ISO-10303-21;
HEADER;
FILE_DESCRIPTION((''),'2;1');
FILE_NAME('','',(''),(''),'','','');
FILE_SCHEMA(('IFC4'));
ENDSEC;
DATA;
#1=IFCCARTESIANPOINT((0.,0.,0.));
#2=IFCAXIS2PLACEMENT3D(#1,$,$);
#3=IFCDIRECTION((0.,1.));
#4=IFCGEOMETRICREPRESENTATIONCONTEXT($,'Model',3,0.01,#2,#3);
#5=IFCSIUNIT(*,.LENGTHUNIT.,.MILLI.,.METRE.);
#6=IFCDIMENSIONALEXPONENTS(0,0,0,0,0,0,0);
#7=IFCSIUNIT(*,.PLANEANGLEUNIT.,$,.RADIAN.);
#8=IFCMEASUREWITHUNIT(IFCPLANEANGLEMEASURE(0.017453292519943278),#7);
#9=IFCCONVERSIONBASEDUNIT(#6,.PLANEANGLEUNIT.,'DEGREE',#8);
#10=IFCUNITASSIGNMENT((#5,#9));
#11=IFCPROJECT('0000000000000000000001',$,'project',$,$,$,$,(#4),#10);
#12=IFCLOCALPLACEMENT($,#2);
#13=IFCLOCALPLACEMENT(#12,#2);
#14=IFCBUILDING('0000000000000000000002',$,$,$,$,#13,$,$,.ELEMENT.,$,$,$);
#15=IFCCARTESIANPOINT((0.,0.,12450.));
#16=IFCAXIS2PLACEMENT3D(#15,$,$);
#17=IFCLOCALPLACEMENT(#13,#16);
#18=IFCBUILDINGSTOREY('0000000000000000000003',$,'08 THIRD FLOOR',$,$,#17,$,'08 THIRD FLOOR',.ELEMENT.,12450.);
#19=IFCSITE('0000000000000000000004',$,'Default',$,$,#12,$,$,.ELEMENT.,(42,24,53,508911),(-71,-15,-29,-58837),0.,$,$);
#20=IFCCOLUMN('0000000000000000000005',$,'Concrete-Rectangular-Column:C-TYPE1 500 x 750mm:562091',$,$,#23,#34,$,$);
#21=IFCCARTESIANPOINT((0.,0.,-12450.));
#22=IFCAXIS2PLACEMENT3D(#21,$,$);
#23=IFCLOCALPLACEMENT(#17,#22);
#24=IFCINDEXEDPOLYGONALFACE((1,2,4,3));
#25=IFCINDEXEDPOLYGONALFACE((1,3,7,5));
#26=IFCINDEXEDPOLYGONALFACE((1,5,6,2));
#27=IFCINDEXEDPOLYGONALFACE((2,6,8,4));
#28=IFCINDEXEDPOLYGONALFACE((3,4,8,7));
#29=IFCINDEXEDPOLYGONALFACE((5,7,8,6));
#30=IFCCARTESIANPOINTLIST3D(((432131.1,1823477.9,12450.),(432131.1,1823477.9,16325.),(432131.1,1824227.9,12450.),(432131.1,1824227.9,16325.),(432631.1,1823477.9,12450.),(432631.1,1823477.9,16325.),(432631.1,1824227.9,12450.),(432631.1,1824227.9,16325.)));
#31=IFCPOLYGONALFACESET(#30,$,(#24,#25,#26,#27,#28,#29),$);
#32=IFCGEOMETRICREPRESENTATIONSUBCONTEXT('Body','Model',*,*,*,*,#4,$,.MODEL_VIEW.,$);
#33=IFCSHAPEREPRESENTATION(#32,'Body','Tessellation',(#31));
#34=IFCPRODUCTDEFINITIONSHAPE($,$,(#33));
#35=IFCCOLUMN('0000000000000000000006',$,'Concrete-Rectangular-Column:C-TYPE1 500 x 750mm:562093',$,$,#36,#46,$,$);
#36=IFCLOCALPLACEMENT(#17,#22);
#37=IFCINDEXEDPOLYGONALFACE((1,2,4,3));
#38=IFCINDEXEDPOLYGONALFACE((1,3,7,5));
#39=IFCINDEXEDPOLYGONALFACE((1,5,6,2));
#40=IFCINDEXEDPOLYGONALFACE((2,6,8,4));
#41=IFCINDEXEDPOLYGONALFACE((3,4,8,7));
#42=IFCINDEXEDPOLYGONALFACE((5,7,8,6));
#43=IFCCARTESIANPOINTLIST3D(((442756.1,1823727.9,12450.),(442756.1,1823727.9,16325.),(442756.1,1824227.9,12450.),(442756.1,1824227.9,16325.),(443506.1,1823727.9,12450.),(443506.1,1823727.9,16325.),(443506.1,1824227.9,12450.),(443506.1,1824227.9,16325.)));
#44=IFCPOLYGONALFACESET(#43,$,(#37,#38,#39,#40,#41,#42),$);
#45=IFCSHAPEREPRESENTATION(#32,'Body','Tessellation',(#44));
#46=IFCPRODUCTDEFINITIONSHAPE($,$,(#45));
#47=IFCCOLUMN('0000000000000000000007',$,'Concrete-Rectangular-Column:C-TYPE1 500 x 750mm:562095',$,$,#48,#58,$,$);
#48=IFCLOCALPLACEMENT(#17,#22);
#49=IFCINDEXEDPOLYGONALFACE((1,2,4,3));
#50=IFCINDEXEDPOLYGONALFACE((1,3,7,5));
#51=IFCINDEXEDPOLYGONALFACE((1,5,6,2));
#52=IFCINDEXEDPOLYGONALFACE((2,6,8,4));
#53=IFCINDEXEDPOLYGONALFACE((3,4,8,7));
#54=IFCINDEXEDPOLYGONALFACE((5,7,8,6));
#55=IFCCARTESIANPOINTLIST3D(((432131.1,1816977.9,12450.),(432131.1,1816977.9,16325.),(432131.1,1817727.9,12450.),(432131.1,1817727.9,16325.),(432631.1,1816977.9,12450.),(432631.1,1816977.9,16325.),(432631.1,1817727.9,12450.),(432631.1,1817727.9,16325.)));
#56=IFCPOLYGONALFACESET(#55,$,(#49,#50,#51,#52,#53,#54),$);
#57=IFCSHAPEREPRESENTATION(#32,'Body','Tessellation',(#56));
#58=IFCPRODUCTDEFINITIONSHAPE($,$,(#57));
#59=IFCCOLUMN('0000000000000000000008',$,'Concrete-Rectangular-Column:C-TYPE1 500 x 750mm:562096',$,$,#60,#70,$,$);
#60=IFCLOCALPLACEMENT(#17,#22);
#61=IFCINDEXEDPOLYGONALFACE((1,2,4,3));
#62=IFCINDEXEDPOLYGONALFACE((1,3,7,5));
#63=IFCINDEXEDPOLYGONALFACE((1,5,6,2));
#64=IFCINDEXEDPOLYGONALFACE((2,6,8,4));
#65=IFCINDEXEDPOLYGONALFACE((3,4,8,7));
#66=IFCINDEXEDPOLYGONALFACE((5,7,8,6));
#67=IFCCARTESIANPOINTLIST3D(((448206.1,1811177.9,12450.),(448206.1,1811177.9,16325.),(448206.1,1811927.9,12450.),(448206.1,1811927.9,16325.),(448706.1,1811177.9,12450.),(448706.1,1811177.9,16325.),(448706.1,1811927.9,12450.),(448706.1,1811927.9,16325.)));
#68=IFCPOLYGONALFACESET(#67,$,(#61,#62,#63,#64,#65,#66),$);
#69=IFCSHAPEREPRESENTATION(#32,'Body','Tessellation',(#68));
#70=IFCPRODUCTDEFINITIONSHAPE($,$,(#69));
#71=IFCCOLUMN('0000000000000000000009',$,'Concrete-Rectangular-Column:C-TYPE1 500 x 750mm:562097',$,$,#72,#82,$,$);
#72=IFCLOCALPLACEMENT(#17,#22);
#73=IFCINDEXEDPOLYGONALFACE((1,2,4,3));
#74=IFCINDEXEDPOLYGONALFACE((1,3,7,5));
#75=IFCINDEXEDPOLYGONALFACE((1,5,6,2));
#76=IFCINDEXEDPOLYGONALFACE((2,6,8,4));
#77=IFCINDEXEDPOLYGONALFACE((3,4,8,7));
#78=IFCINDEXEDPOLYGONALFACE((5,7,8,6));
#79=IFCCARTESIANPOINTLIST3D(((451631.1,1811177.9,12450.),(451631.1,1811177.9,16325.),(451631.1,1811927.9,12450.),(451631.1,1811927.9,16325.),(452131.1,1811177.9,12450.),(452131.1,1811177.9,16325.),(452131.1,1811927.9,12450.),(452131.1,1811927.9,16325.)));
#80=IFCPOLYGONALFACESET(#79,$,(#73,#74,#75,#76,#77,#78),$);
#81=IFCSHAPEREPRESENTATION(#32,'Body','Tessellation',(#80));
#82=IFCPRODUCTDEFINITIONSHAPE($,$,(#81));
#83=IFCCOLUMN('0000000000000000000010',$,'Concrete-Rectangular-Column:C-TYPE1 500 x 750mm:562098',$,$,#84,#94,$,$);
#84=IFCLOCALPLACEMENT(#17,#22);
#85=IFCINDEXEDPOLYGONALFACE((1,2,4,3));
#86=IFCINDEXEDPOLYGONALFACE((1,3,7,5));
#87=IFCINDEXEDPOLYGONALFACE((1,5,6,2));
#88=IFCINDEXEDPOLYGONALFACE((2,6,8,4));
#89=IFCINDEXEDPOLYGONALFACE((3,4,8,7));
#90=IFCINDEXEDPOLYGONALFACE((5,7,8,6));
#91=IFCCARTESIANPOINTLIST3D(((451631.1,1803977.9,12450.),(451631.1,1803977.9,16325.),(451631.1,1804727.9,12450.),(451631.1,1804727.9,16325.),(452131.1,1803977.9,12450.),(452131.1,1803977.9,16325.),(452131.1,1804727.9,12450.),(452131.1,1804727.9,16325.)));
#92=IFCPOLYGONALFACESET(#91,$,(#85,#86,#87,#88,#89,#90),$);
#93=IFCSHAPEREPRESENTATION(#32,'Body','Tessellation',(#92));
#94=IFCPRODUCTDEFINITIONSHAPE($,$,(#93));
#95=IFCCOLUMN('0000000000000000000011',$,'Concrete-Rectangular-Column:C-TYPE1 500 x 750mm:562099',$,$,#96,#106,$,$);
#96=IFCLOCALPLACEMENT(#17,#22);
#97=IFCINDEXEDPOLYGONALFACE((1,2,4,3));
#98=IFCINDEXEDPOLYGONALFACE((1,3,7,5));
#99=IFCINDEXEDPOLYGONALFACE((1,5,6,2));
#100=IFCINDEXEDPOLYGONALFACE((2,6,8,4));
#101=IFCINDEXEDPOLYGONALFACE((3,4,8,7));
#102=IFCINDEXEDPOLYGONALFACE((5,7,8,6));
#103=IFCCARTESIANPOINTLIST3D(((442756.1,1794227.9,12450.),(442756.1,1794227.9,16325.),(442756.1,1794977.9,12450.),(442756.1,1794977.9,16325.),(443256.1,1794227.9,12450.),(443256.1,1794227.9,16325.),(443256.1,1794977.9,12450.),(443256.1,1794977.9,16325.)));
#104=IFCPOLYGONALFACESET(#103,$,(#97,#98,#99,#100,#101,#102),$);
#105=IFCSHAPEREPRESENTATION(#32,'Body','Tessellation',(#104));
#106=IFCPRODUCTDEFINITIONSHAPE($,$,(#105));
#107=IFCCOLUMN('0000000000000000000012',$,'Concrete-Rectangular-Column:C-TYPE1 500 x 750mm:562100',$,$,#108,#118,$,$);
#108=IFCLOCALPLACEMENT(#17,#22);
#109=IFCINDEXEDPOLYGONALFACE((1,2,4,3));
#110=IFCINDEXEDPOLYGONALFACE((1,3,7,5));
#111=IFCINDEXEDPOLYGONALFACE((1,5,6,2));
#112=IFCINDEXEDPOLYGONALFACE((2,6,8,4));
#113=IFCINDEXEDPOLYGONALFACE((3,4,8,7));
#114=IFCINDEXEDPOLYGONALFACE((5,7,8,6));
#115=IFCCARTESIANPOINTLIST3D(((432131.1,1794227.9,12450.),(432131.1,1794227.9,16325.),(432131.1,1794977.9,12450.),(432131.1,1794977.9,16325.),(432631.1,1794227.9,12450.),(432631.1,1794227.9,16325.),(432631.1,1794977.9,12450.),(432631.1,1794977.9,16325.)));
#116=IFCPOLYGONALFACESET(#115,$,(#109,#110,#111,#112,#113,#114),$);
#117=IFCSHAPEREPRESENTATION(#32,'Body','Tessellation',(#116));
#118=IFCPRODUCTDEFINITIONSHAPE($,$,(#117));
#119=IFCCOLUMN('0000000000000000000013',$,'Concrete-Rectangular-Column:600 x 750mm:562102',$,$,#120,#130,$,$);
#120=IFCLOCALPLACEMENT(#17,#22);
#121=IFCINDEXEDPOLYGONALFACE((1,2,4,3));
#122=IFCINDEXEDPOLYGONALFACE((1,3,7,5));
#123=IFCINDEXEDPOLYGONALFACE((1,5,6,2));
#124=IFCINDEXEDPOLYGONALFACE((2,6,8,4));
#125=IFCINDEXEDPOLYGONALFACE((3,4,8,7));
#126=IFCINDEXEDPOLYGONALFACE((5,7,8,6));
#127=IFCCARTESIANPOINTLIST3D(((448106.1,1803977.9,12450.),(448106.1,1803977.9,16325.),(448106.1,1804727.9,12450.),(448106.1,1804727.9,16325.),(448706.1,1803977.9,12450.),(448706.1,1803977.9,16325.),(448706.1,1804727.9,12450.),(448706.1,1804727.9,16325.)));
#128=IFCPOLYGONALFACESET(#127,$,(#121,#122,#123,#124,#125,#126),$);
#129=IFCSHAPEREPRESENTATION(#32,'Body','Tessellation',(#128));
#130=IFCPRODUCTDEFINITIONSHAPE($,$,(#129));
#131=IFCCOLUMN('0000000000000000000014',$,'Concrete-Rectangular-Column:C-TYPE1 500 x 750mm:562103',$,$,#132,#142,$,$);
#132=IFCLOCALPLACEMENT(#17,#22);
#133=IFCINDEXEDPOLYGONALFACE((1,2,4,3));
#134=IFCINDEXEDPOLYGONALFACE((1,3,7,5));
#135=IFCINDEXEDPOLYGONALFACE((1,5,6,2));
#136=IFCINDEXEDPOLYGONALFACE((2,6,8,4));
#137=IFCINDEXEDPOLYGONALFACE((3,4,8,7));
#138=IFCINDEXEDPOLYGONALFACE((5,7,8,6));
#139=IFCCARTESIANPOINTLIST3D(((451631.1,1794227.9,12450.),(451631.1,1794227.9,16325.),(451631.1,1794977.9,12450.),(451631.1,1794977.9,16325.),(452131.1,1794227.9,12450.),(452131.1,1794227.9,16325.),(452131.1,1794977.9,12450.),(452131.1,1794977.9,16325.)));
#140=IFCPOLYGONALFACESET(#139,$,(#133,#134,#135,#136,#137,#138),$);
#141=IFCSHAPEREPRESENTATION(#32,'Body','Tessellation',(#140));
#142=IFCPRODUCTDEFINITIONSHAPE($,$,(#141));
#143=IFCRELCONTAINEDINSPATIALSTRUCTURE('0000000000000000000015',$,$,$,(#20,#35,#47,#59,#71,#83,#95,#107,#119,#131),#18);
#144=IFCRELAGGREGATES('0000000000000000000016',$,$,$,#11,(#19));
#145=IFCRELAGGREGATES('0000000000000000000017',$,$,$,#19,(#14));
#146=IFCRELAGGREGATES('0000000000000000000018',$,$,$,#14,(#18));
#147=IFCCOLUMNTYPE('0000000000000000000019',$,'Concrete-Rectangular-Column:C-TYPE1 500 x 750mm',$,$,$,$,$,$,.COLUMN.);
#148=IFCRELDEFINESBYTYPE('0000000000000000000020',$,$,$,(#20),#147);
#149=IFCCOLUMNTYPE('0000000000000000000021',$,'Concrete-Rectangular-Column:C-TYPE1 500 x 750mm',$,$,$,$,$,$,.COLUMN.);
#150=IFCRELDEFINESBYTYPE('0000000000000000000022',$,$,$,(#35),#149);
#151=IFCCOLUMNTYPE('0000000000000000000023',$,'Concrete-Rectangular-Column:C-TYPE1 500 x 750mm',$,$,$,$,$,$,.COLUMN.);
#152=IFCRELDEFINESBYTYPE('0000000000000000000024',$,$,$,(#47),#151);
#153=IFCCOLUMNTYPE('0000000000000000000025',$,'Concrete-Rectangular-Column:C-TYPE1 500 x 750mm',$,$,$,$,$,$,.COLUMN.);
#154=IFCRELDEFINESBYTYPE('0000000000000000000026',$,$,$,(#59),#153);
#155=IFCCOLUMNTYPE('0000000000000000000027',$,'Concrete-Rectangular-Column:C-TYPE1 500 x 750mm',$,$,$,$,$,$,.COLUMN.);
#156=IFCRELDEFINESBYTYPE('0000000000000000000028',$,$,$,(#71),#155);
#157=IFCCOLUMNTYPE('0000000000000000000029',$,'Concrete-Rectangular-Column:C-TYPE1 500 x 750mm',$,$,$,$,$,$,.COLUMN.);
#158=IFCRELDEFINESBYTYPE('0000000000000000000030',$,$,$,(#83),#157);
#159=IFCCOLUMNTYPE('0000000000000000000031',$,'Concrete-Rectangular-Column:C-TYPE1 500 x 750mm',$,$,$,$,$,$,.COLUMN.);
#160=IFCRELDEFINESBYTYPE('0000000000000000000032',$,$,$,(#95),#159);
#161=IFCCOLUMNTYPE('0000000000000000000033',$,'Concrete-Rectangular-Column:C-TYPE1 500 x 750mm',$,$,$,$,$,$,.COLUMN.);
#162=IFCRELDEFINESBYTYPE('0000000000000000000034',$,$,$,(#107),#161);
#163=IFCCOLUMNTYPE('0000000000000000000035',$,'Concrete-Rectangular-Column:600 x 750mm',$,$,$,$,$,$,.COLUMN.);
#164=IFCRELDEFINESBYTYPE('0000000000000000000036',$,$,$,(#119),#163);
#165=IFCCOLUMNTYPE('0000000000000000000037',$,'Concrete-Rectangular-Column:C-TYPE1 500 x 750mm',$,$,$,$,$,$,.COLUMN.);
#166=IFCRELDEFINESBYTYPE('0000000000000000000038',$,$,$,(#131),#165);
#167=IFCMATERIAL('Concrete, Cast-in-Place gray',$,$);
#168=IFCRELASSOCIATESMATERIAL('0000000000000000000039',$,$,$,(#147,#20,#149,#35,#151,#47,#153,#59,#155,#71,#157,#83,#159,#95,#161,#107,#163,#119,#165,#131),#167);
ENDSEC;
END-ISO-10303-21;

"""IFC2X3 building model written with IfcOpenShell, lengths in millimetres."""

from ifc_helpers import new_model, entity, si_unit, converted_unit, direction, frame, frame_2d, origin, place, context, subcontext, project, spatial, rectangle, extrude, source, transform, mapped, material, type_object, type_shapes, element, save


model = new_model("IFC2X3")

# Units and contexts
model_context = context("Model", 3, precision=0.01, world=origin(), true_north=direction((0.0, 1.0)))
body_context = subcontext(model_context, "Body", "Model", "MODEL_VIEW")
ifc_project = project(units=[si_unit("LENGTHUNIT", "METRE", prefix="MILLI"), converted_unit("PLANEANGLEUNIT", "DEGREE", entity("IfcPlaneAngleMeasure", 0.017453292519943278), si_unit("PLANEANGLEUNIT", "RADIAN"), dimensions=[0, 0, 0, 0, 0, 0, 0])], contexts=[model_context])

# Site, building, storey
site_placement = place(None, origin())
site = spatial("IfcSite", under=ifc_project, at=site_placement, Name="Default", CompositionType="ELEMENT", RefLatitude=(42, 24, 53, 508911), RefLongitude=(-71, -15, -29, -58837), RefElevation=0.0)
building_placement = place(site_placement, origin())
building = spatial("IfcBuilding", under=site, at=building_placement, CompositionType="ELEMENT")
storey_placement = place(building_placement, frame((0.0, 0.0, 12450.0)))
storey = spatial("IfcBuildingStorey", under=building, at=storey_placement, Name="08 THIRD FLOOR", LongName="08 THIRD FLOOR", CompositionType="ELEMENT", Elevation=12450.0)

# Columns
ifc_material = material(Name="Concrete, Cast-in-Place gray")
column_type_1 = type_object("IfcColumnType", Name="Concrete-Rectangular-Column:C-TYPE1 500 x 750mm", PredefinedType="COLUMN", material=ifc_material)
shared_shape_1 = source(origin(), body_context, "Body", "SweptSolid", [
    extrude(rectangle(XDim=3875.0, YDim=750.0, at=frame_2d((0.0, 0.0), x_axis=(1.0, 0.0))), frame((432131.1, 1823852.9, 14387.5), z_axis=(1.0, 0.0, 0.0), x_axis=(0.0, 0.0, 1.0)), (0.0, 0.0, 1.0), 500.0),
])
type_shapes(column_type_1, [shared_shape_1])
column_1_placement = place(storey_placement, frame((0.0, 0.0, -12450.0)))
element("IfcColumn", 1, at=column_1_placement, inside=storey, type_object=column_type_1, material=ifc_material, Name="Concrete-Rectangular-Column:C-TYPE1 500 x 750mm:562091", context=body_context, shape_type="MappedRepresentation", body=[
    mapped(shared_shape_1, transform((0.0, 0.0, 0.0), scale=1.0)),
])
column_type_2 = type_object("IfcColumnType", Name="Concrete-Rectangular-Column:C-TYPE1 500 x 750mm", PredefinedType="COLUMN", material=ifc_material)
shared_shape_2 = source(origin(), body_context, "Body", "SweptSolid", [
    extrude(rectangle(XDim=500.0, YDim=750.0, at=frame_2d((0.0, 0.0), x_axis=(1.0, 0.0))), frame((443131.1, 1823977.9, 12450.0), z_axis=(0.0, 0.0, 1.0), x_axis=(0.0, -1.0, 0.0)), (0.0, 0.0, 1.0), 3875.0),
])
type_shapes(column_type_2, [shared_shape_2])
column_2_placement = place(storey_placement, frame((0.0, 0.0, -12450.0)))
element("IfcColumn", 2, at=column_2_placement, inside=storey, type_object=column_type_2, material=ifc_material, Name="Concrete-Rectangular-Column:C-TYPE1 500 x 750mm:562093", context=body_context, shape_type="MappedRepresentation", body=[
    mapped(shared_shape_2, transform((0.0, 0.0, 0.0), scale=1.0)),
])
column_type_3 = type_object("IfcColumnType", Name="Concrete-Rectangular-Column:C-TYPE1 500 x 750mm", PredefinedType="COLUMN", material=ifc_material)
shared_shape_3 = source(origin(), body_context, "Body", "SweptSolid", [
    extrude(rectangle(XDim=3875.0, YDim=750.0, at=frame_2d((0.0, 0.0), x_axis=(1.0, 0.0))), frame((432131.1, 1817352.9, 14387.5), z_axis=(1.0, 0.0, 0.0), x_axis=(0.0, 0.0, 1.0)), (0.0, 0.0, 1.0), 500.0),
])
type_shapes(column_type_3, [shared_shape_3])
column_3_placement = place(storey_placement, frame((0.0, 0.0, -12450.0)))
element("IfcColumn", 3, at=column_3_placement, inside=storey, type_object=column_type_3, material=ifc_material, Name="Concrete-Rectangular-Column:C-TYPE1 500 x 750mm:562095", context=body_context, shape_type="MappedRepresentation", body=[
    mapped(shared_shape_3, transform((0.0, 0.0, 0.0), scale=1.0)),
])
column_type_4 = type_object("IfcColumnType", Name="Concrete-Rectangular-Column:C-TYPE1 500 x 750mm", PredefinedType="COLUMN", material=ifc_material)
shared_shape_4 = source(origin(), body_context, "Body", "SweptSolid", [
    extrude(rectangle(XDim=3875.0, YDim=750.0, at=frame_2d((0.0, 0.0), x_axis=(1.0, 0.0))), frame((448206.1, 1811552.9, 14387.5), z_axis=(1.0, 0.0, 0.0), x_axis=(0.0, 0.0, 1.0)), (0.0, 0.0, 1.0), 500.0),
])
type_shapes(column_type_4, [shared_shape_4])
column_4_placement = place(storey_placement, frame((0.0, 0.0, -12450.0)))
element("IfcColumn", 4, at=column_4_placement, inside=storey, type_object=column_type_4, material=ifc_material, Name="Concrete-Rectangular-Column:C-TYPE1 500 x 750mm:562096", context=body_context, shape_type="MappedRepresentation", body=[
    mapped(shared_shape_4, transform((0.0, 0.0, 0.0), scale=1.0)),
])
column_type_5 = type_object("IfcColumnType", Name="Concrete-Rectangular-Column:C-TYPE1 500 x 750mm", PredefinedType="COLUMN", material=ifc_material)
shared_shape_5 = source(origin(), body_context, "Body", "SweptSolid", [
    extrude(rectangle(XDim=3875.0, YDim=750.0, at=frame_2d((0.0, 0.0), x_axis=(1.0, 0.0))), frame((451631.1, 1811552.9, 14387.5), z_axis=(1.0, 0.0, 0.0), x_axis=(0.0, 0.0, 1.0)), (0.0, 0.0, 1.0), 500.0),
])
type_shapes(column_type_5, [shared_shape_5])
column_5_placement = place(storey_placement, frame((0.0, 0.0, -12450.0)))
element("IfcColumn", 5, at=column_5_placement, inside=storey, type_object=column_type_5, material=ifc_material, Name="Concrete-Rectangular-Column:C-TYPE1 500 x 750mm:562097", context=body_context, shape_type="MappedRepresentation", body=[
    mapped(shared_shape_5, transform((0.0, 0.0, 0.0), scale=1.0)),
])
column_type_6 = type_object("IfcColumnType", Name="Concrete-Rectangular-Column:C-TYPE1 500 x 750mm", PredefinedType="COLUMN", material=ifc_material)
shared_shape_6 = source(origin(), body_context, "Body", "SweptSolid", [
    extrude(rectangle(XDim=3875.0, YDim=750.0, at=frame_2d((0.0, 0.0), x_axis=(1.0, 0.0))), frame((451631.1, 1804352.9, 14387.5), z_axis=(1.0, 0.0, 0.0), x_axis=(0.0, 0.0, 1.0)), (0.0, 0.0, 1.0), 500.0),
])
type_shapes(column_type_6, [shared_shape_6])
column_6_placement = place(storey_placement, frame((0.0, 0.0, -12450.0)))
element("IfcColumn", 6, at=column_6_placement, inside=storey, type_object=column_type_6, material=ifc_material, Name="Concrete-Rectangular-Column:C-TYPE1 500 x 750mm:562098", context=body_context, shape_type="MappedRepresentation", body=[
    mapped(shared_shape_6, transform((0.0, 0.0, 0.0), scale=1.0)),
])
column_type_7 = type_object("IfcColumnType", Name="Concrete-Rectangular-Column:C-TYPE1 500 x 750mm", PredefinedType="COLUMN", material=ifc_material)
shared_shape_7 = source(origin(), body_context, "Body", "SweptSolid", [
    extrude(rectangle(XDim=3875.0, YDim=750.0, at=frame_2d((0.0, 0.0), x_axis=(1.0, 0.0))), frame((442756.1, 1794602.9, 14387.5), z_axis=(1.0, 0.0, 0.0), x_axis=(0.0, 0.0, 1.0)), (0.0, 0.0, 1.0), 500.0),
])
type_shapes(column_type_7, [shared_shape_7])
column_7_placement = place(storey_placement, frame((0.0, 0.0, -12450.0)))
element("IfcColumn", 7, at=column_7_placement, inside=storey, type_object=column_type_7, material=ifc_material, Name="Concrete-Rectangular-Column:C-TYPE1 500 x 750mm:562099", context=body_context, shape_type="MappedRepresentation", body=[
    mapped(shared_shape_7, transform((0.0, 0.0, 0.0), scale=1.0)),
])
column_type_8 = type_object("IfcColumnType", Name="Concrete-Rectangular-Column:C-TYPE1 500 x 750mm", PredefinedType="COLUMN", material=ifc_material)
shared_shape_8 = source(origin(), body_context, "Body", "SweptSolid", [
    extrude(rectangle(XDim=3875.0, YDim=750.0, at=frame_2d((0.0, 0.0), x_axis=(1.0, 0.0))), frame((432131.1, 1794602.9, 14387.5), z_axis=(1.0, 0.0, 0.0), x_axis=(0.0, 0.0, 1.0)), (0.0, 0.0, 1.0), 500.0),
])
type_shapes(column_type_8, [shared_shape_8])
column_8_placement = place(storey_placement, frame((0.0, 0.0, -12450.0)))
element("IfcColumn", 8, at=column_8_placement, inside=storey, type_object=column_type_8, material=ifc_material, Name="Concrete-Rectangular-Column:C-TYPE1 500 x 750mm:562100", context=body_context, shape_type="MappedRepresentation", body=[
    mapped(shared_shape_8, transform((0.0, 0.0, 0.0), scale=1.0)),
])
column_type_9 = type_object("IfcColumnType", Name="Concrete-Rectangular-Column:600 x 750mm", PredefinedType="COLUMN", material=ifc_material)
shared_shape_9 = source(origin(), body_context, "Body", "SweptSolid", [
    extrude(rectangle(XDim=3875.0, YDim=750.0, at=frame_2d((0.0, 0.0), x_axis=(1.0, 0.0))), frame((448106.1, 1804352.9, 14387.5), z_axis=(1.0, 0.0, 0.0), x_axis=(0.0, 0.0, 1.0)), (0.0, 0.0, 1.0), 600.0),
])
type_shapes(column_type_9, [shared_shape_9])
column_9_placement = place(storey_placement, frame((0.0, 0.0, -12450.0)))
element("IfcColumn", 9, at=column_9_placement, inside=storey, type_object=column_type_9, material=ifc_material, Name="Concrete-Rectangular-Column:600 x 750mm:562102", context=body_context, shape_type="MappedRepresentation", body=[
    mapped(shared_shape_9, transform((0.0, 0.0, 0.0), scale=1.0)),
])
column_type_10 = type_object("IfcColumnType", Name="Concrete-Rectangular-Column:C-TYPE1 500 x 750mm", PredefinedType="COLUMN", material=ifc_material)
shared_shape_10 = source(origin(), body_context, "Body", "SweptSolid", [
    extrude(rectangle(XDim=3875.0, YDim=750.0, at=frame_2d((0.0, 0.0), x_axis=(1.0, 0.0))), frame((451631.1, 1794602.9, 14387.5), z_axis=(1.0, 0.0, 0.0), x_axis=(0.0, 0.0, 1.0)), (0.0, 0.0, 1.0), 500.0),
])
type_shapes(column_type_10, [shared_shape_10])
column_10_placement = place(storey_placement, frame((0.0, 0.0, -12450.0)))
element("IfcColumn", 10, at=column_10_placement, inside=storey, type_object=column_type_10, material=ifc_material, Name="Concrete-Rectangular-Column:C-TYPE1 500 x 750mm:562103", context=body_context, shape_type="MappedRepresentation", body=[
    mapped(shared_shape_10, transform((0.0, 0.0, 0.0), scale=1.0)),
])

save(model, "model.ifc")
